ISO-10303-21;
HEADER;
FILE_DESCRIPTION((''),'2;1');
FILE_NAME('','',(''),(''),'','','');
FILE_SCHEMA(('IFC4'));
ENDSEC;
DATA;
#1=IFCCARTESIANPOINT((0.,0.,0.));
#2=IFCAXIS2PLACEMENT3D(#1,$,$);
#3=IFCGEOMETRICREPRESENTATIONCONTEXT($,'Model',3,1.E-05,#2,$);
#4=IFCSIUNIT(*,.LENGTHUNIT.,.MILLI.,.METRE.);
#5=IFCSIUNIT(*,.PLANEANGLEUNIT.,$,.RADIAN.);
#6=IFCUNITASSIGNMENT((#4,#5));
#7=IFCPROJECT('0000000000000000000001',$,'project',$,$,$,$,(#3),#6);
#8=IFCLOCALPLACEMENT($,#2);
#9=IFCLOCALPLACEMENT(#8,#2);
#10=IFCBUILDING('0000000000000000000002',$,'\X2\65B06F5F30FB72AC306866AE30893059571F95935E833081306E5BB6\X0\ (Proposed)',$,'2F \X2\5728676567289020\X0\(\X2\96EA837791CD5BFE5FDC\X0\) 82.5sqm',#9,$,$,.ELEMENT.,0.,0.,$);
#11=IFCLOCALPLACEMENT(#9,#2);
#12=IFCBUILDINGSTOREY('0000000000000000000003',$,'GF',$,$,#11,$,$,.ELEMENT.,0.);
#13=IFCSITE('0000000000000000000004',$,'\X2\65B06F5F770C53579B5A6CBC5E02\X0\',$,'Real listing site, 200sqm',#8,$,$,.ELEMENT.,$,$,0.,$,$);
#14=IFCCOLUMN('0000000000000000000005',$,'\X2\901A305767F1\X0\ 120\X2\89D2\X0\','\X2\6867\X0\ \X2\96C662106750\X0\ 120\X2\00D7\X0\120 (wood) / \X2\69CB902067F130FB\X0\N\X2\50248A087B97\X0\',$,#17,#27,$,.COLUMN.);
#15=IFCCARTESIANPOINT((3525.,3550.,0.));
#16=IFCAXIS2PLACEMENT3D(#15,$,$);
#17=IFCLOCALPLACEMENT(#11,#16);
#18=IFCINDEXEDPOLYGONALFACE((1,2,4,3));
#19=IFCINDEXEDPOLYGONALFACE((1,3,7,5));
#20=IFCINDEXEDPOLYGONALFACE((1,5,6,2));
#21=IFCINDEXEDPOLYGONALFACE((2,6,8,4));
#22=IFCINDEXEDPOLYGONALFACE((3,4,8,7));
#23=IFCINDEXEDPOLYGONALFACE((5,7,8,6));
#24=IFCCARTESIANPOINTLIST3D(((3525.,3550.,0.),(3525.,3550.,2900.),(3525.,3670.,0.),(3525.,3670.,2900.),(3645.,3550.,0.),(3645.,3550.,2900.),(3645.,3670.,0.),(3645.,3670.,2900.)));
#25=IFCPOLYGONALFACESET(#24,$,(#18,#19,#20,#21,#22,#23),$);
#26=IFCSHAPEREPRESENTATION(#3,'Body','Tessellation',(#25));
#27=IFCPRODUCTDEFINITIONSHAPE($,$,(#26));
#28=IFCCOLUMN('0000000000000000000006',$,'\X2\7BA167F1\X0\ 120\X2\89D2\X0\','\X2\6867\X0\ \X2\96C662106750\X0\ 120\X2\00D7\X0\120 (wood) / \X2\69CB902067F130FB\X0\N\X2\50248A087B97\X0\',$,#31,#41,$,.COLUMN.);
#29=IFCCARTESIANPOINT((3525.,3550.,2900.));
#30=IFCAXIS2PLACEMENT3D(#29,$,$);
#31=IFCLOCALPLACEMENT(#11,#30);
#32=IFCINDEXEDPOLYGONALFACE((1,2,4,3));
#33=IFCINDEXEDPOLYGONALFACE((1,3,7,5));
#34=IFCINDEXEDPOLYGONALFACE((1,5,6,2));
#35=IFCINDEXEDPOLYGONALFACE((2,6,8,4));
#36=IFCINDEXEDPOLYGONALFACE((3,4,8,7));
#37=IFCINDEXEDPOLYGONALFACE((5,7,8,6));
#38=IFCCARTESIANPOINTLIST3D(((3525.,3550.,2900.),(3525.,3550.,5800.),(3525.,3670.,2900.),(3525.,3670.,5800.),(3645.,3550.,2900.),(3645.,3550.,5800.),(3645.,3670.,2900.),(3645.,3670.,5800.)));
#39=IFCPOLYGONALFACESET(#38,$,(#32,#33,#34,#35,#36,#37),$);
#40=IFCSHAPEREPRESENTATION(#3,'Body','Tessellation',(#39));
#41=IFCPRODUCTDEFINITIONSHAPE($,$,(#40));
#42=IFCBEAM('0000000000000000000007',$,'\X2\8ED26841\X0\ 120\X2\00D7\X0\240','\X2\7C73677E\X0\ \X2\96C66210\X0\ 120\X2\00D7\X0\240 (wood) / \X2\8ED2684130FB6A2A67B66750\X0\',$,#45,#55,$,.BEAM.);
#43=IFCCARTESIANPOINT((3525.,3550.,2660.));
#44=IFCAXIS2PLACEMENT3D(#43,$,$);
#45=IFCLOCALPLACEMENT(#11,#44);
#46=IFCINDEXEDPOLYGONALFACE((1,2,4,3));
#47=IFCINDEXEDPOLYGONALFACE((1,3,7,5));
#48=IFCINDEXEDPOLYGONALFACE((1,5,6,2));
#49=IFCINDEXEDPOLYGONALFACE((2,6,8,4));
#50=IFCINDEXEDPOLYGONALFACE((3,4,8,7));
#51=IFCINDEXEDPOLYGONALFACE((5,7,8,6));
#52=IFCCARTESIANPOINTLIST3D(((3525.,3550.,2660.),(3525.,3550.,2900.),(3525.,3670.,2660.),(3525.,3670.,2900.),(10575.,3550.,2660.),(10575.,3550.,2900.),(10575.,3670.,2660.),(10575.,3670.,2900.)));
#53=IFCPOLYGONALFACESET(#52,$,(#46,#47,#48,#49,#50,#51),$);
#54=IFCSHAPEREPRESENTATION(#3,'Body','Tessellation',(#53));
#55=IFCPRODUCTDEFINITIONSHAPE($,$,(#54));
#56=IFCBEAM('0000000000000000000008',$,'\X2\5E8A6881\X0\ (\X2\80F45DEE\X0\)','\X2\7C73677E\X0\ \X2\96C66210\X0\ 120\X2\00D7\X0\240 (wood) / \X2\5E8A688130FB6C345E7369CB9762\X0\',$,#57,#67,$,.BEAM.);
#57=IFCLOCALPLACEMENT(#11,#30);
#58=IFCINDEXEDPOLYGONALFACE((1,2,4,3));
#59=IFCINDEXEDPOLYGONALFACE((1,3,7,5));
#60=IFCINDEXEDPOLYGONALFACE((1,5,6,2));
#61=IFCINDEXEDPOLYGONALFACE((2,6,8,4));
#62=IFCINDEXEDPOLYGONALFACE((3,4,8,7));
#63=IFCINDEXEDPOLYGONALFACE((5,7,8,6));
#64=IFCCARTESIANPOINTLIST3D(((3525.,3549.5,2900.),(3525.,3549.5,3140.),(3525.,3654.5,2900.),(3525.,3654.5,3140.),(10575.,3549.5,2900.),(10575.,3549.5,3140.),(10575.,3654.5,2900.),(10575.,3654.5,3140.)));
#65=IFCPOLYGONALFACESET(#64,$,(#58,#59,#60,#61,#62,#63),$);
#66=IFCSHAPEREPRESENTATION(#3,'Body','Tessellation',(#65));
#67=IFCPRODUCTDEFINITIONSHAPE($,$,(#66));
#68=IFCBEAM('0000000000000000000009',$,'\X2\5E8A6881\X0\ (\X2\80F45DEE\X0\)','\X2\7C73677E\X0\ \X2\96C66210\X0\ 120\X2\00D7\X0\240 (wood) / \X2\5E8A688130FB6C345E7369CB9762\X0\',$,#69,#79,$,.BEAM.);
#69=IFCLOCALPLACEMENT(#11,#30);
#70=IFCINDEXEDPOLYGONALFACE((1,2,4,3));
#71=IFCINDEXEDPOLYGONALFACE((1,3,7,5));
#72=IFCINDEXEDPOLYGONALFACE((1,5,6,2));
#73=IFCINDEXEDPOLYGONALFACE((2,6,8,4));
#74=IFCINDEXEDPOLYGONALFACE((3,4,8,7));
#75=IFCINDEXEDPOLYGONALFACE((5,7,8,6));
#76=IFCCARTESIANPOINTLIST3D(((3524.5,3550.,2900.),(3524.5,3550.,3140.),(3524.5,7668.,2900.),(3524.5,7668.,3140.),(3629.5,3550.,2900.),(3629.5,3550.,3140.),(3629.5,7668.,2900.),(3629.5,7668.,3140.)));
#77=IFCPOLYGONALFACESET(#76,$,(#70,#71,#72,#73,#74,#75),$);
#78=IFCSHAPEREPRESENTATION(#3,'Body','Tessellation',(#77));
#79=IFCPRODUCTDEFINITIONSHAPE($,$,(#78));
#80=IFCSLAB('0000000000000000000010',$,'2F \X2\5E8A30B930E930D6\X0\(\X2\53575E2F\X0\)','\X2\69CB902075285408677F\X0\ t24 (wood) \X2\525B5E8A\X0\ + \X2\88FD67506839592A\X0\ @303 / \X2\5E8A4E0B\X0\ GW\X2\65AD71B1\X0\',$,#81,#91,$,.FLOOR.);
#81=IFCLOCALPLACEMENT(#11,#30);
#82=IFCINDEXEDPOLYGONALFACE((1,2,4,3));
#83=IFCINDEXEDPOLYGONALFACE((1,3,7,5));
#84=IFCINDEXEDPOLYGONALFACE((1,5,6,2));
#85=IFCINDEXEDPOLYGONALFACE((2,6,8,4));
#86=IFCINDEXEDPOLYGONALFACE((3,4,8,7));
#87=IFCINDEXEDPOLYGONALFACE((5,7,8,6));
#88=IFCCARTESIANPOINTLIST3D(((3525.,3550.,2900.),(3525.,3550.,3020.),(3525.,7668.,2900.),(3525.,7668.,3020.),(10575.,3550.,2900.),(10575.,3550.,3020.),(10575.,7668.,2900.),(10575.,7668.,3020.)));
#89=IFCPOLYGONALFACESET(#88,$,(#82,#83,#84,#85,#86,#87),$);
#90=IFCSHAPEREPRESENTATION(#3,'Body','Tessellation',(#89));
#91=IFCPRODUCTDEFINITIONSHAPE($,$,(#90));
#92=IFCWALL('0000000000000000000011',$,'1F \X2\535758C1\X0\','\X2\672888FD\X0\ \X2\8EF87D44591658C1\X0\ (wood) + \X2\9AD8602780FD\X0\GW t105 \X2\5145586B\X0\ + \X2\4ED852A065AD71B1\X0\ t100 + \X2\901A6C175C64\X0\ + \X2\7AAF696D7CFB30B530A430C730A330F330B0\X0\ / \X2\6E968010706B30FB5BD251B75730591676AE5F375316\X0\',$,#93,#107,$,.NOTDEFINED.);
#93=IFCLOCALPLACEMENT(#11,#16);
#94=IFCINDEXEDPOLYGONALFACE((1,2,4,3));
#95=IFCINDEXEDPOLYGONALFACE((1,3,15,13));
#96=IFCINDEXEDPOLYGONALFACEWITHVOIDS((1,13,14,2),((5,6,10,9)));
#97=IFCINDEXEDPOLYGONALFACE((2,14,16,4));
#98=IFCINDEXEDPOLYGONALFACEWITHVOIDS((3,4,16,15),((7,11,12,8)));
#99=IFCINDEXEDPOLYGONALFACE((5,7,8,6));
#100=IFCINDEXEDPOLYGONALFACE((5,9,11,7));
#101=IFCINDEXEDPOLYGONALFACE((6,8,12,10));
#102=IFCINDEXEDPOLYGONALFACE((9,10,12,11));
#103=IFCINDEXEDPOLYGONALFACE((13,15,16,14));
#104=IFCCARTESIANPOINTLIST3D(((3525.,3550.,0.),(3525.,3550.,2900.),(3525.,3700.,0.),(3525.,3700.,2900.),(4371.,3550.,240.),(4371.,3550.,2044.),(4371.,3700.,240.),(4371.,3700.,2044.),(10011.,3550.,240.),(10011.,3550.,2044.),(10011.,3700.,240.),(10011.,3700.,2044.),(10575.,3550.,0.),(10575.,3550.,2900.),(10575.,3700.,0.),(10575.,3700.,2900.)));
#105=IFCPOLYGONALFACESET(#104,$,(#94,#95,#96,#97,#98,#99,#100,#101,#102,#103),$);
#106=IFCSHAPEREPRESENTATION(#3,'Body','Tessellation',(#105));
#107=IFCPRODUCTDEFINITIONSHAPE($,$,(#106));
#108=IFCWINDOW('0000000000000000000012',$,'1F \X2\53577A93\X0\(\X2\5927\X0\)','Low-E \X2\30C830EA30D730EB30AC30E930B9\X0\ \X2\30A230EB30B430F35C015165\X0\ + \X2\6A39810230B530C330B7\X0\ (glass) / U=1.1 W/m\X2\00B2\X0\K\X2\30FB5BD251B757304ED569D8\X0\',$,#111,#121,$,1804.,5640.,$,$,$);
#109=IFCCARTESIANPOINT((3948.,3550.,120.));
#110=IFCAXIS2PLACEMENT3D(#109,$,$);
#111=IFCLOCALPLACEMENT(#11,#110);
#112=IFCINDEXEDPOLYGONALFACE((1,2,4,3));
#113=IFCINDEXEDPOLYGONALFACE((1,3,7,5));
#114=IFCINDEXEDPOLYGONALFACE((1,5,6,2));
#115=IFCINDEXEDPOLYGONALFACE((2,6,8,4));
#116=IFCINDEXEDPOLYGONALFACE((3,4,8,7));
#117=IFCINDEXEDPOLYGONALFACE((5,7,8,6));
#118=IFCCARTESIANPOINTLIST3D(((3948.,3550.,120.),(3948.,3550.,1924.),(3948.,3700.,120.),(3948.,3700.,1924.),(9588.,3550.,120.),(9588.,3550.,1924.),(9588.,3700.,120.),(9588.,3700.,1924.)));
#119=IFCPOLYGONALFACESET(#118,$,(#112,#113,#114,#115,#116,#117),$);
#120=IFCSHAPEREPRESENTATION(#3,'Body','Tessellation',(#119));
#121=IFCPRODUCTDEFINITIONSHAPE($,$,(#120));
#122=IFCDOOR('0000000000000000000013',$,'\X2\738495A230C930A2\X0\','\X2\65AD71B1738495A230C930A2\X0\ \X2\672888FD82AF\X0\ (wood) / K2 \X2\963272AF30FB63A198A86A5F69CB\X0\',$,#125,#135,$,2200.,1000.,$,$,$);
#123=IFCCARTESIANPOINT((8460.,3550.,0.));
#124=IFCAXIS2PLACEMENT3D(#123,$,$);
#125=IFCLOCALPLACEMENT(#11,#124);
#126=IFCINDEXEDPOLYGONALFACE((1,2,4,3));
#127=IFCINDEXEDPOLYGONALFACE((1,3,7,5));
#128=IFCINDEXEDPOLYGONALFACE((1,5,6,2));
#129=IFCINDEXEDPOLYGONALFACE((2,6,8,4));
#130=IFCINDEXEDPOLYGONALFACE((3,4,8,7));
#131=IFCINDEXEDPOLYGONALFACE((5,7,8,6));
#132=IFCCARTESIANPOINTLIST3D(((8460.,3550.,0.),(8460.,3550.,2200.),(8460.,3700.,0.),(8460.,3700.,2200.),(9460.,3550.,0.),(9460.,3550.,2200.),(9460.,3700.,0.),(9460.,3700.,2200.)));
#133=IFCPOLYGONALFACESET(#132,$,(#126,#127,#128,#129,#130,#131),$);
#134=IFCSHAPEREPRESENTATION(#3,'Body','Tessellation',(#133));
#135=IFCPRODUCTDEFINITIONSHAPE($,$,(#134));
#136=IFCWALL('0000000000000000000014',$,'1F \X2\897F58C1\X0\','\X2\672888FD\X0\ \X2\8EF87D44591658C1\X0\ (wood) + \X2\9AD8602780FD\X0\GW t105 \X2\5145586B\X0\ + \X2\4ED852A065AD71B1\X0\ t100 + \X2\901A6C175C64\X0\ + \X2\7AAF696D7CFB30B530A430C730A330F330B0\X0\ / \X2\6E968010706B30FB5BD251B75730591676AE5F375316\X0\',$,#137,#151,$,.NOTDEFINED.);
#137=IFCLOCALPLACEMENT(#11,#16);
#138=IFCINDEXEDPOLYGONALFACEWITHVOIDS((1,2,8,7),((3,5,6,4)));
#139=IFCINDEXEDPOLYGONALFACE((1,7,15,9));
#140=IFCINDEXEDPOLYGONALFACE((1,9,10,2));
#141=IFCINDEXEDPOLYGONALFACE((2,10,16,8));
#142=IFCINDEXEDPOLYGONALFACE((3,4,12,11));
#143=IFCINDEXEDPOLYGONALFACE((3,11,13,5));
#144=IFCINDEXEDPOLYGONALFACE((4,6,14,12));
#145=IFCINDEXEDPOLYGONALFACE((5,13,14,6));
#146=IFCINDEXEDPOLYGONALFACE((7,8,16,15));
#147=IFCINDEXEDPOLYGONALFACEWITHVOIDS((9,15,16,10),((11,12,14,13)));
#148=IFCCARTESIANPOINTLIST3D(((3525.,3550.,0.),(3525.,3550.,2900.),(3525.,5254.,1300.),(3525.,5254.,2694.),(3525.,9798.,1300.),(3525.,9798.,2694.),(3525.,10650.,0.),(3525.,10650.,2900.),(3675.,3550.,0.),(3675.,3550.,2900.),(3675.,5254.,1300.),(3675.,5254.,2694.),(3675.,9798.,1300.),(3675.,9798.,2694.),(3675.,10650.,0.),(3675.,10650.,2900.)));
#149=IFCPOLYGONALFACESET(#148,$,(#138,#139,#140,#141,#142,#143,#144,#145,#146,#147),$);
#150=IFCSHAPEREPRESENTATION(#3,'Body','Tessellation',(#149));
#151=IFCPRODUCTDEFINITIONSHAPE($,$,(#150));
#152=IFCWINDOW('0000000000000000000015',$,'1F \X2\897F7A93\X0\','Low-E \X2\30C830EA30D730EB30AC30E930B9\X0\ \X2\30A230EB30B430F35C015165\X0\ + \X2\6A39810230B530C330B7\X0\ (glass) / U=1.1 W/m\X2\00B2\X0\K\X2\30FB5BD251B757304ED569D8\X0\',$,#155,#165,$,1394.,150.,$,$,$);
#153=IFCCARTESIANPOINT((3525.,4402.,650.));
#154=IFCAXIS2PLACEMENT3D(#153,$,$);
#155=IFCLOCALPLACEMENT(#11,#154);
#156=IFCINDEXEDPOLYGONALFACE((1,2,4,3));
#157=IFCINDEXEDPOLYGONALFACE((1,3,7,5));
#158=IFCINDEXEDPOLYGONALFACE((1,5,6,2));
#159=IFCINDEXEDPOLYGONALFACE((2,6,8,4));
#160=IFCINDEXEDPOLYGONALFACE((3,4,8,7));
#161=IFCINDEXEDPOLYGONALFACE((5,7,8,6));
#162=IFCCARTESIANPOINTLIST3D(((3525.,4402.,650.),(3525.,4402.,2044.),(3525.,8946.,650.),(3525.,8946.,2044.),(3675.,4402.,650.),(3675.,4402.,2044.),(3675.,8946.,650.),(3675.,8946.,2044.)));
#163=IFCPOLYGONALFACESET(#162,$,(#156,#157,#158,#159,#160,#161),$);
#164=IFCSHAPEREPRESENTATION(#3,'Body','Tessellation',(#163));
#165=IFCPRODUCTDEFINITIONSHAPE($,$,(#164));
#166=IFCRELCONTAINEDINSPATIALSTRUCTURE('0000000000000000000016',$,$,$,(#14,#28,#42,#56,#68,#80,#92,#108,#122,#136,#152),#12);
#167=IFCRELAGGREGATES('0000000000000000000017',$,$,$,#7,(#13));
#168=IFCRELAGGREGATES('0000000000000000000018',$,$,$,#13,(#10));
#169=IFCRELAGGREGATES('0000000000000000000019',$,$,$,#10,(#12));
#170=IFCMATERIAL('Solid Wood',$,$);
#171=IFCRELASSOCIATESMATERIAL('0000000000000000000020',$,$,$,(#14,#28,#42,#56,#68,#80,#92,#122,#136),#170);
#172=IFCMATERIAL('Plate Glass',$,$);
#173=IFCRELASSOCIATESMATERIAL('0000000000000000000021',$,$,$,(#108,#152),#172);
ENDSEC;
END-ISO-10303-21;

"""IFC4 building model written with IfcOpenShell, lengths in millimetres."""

from ifc_helpers import new_model, si_unit, frame, frame_2d, origin, place, context, project, spatial, rectangle, extrude, material, element, fill, save


model = new_model("IFC4")

# Units and contexts
model_context = context("Model", 3, precision=1e-05, world=origin())
ifc_project = project(units=[si_unit("LENGTHUNIT", "METRE", prefix="MILLI"), si_unit("PLANEANGLEUNIT", "RADIAN")], contexts=[model_context])

# Site, building, storey
site_placement = place(None, origin())
site = spatial("IfcSite", under=ifc_project, at=site_placement, Name="新潟県南魚沼市", ObjectType="Real listing site, 200sqm", CompositionType="ELEMENT", RefElevation=0.0)
building_placement = place(site_placement, origin())
building = spatial("IfcBuilding", under=site, at=building_placement, Name="新潟・犬と暮らす土間広めの家 (Proposed)", ObjectType="2F 在来木造(雪荷重対応) 82.5sqm", CompositionType="ELEMENT", ElevationOfRefHeight=0.0, ElevationOfTerrain=0.0)
storey_placement = place(building_placement, origin())
storey = spatial("IfcBuildingStorey", under=building, at=storey_placement, Name="GF", CompositionType="ELEMENT", Elevation=0.0)

# Columns
ifc_material_1 = material(Name="Solid Wood")
column_1_placement = place(storey_placement, frame((3525.0, 3550.0, 0.0)))
element("IfcColumn", 1, at=column_1_placement, inside=storey, material=ifc_material_1, Name="通し柱 120角", Description="桧 集成材 120×120 (wood) / 構造柱・N値計算", PredefinedType="COLUMN", context=model_context, shape_type="SweptSolid", body=[
    extrude(rectangle(XDim=120.0, YDim=120.0, at=frame_2d((60.0, 60.0))), frame((3525.0, 3550.0, 0.0)), (0.0, 0.0, 1.0), 2900.0),
])
column_2_placement = place(storey_placement, frame((3525.0, 3550.0, 2900.0)))
element("IfcColumn", 2, at=column_2_placement, inside=storey, material=ifc_material_1, Name="管柱 120角", Description="桧 集成材 120×120 (wood) / 構造柱・N値計算", PredefinedType="COLUMN", context=model_context, shape_type="SweptSolid", body=[
    extrude(rectangle(XDim=120.0, YDim=120.0, at=frame_2d((60.0, 60.0))), frame((3525.0, 3550.0, 2900.0)), (0.0, 0.0, 1.0), 2900.0),
])

# Beams
beam_1_placement = place(storey_placement, frame((3525.0, 3550.0, 2660.0)))
element("IfcBeam", 3, at=beam_1_placement, inside=storey, material=ifc_material_1, Name="軒桁 120×240", Description="米松 集成 120×240 (wood) / 軒桁・横架材", PredefinedType="BEAM", context=model_context, shape_type="SweptSolid", body=[
    extrude(rectangle(XDim=7050.0, YDim=120.0, at=frame_2d((3525.0, 60.0))), frame((3525.0, 3550.0, 2660.0)), (0.0, 0.0, 1.0), 240.0),
])
beam_2_placement = place(storey_placement, frame((3525.0, 3550.0, 2900.0)))
element("IfcBeam", 4, at=beam_2_placement, inside=storey, material=ifc_material_1, Name="床梁 (胴差)", Description="米松 集成 120×240 (wood) / 床梁・水平構面", PredefinedType="BEAM", context=model_context, shape_type="SweptSolid", body=[
    extrude(rectangle(XDim=7050.0, YDim=105.0, at=frame_2d((3525.0, 52.0))), frame((3525.0, 3550.0, 2900.0)), (0.0, 0.0, 1.0), 240.0),
])
beam_3_placement = place(storey_placement, frame((3525.0, 3550.0, 2900.0)))
element("IfcBeam", 5, at=beam_3_placement, inside=storey, material=ifc_material_1, Name="床梁 (胴差)", Description="米松 集成 120×240 (wood) / 床梁・水平構面", PredefinedType="BEAM", context=model_context, shape_type="SweptSolid", body=[
    extrude(rectangle(XDim=105.0, YDim=4118.0, at=frame_2d((52.0, 2059.0))), frame((3525.0, 3550.0, 2900.0)), (0.0, 0.0, 1.0), 240.0),
])

# Slab
slab_1_placement = place(storey_placement, frame((3525.0, 3550.0, 2900.0)))
element("IfcSlab", 6, at=slab_1_placement, inside=storey, material=ifc_material_1, Name="2F 床スラブ(南帯)", Description="構造用合板 t24 (wood) 剛床 + 製材根太 @303 / 床下 GW断熱", PredefinedType="FLOOR", context=model_context, shape_type="SweptSolid", body=[
    extrude(rectangle(XDim=7050.0, YDim=4118.0, at=frame_2d((3525.0, 2059.0))), frame((3525.0, 3550.0, 2900.0)), (0.0, 0.0, 1.0), 120.0),
])

# Wall, openings, window, door
wall_1_placement = place(storey_placement, frame((3525.0, 3550.0, 0.0)))
wall_1 = element("IfcWall", 7, at=wall_1_placement, inside=storey, material=ifc_material_1, Name="1F 南壁", Description="木製 軸組外壁 (wood) + 高性能GW t105 充填 + 付加断熱 t100 + 通気層 + 窯業系サイディング / 準耐火・寒冷地外皮強化", PredefinedType="NOTDEFINED", context=model_context, shape_type="SweptSolid", body=[
    extrude(rectangle(XDim=7050.0, YDim=150.0, at=frame_2d((3525.0, 75.0))), frame((3525.0, 3550.0, 0.0)), (0.0, 0.0, 1.0), 2900.0),
])
opening_1_placement = place(storey_placement, frame((3948.0, 3550.0, 120.0)))
opening_1 = element("IfcOpeningElement", 8, at=opening_1_placement, cuts=wall_1, PredefinedType="NOTDEFINED", context=model_context, shape_type="SweptSolid", body=[
    extrude(rectangle(XDim=5640.0, YDim=150.0, at=frame_2d((2820.0, 75.0))), frame((3948.0, 3550.0, 120.0)), (0.0, 0.0, 1.0), 1804.0),
])
opening_2_placement = place(storey_placement, frame((8460.0, 3550.0, 0.0)))
opening_2 = element("IfcOpeningElement", 9, at=opening_2_placement, cuts=wall_1, PredefinedType="NOTDEFINED", context=model_context, shape_type="SweptSolid", body=[
    extrude(rectangle(XDim=1000.0, YDim=150.0, at=frame_2d((500.0, 75.0))), frame((8460.0, 3550.0, 0.0)), (0.0, 0.0, 1.0), 2200.0),
])
ifc_material_2 = material(Name="Plate Glass")
window_1_placement = place(storey_placement, frame((3948.0, 3550.0, 120.0)))
window_1 = element("IfcWindow", 10, at=window_1_placement, inside=storey, material=ifc_material_2, Name="1F 南窓(大)", Description="Low-E トリプルガラス アルゴン封入 + 樹脂サッシ (glass) / U=1.1 W/m²K・寒冷地仕様", OverallHeight=1804.0, OverallWidth=5640.0, context=model_context, shape_type="SweptSolid", body=[
    extrude(rectangle(XDim=5640.0, YDim=150.0, at=frame_2d((2820.0, 75.0))), frame((3948.0, 3550.0, 120.0)), (0.0, 0.0, 1.0), 1804.0),
])
fill(opening_1, window_1)
door_placement = place(storey_placement, frame((8460.0, 3550.0, 0.0)))
door = element("IfcDoor", 11, at=door_placement, inside=storey, material=ifc_material_1, Name="玄関ドア", Description="断熱玄関ドア 木製芯 (wood) / K2 防犯・採風機構", OverallHeight=2200.0, OverallWidth=1000.0, context=model_context, shape_type="SweptSolid", body=[
    extrude(rectangle(XDim=1000.0, YDim=150.0, at=frame_2d((500.0, 75.0))), frame((8460.0, 3550.0, 0.0)), (0.0, 0.0, 1.0), 2200.0),
])
fill(opening_2, door)

# Wall, opening, window
wall_2_placement = place(storey_placement, frame((3525.0, 3550.0, 0.0)))
wall_2 = element("IfcWall", 12, at=wall_2_placement, inside=storey, material=ifc_material_1, Name="1F 西壁", Description="木製 軸組外壁 (wood) + 高性能GW t105 充填 + 付加断熱 t100 + 通気層 + 窯業系サイディング / 準耐火・寒冷地外皮強化", PredefinedType="NOTDEFINED", context=model_context, shape_type="SweptSolid", body=[
    extrude(rectangle(XDim=150.0, YDim=7100.0, at=frame_2d((75.0, 3550.0))), frame((3525.0, 3550.0, 0.0)), (0.0, 0.0, 1.0), 2900.0),
])
opening_3_placement = place(storey_placement, frame((3525.0, 4402.0, 650.0)))
opening_3 = element("IfcOpeningElement", 13, at=opening_3_placement, cuts=wall_2, PredefinedType="NOTDEFINED", context=model_context, shape_type="SweptSolid", body=[
    extrude(rectangle(XDim=150.0, YDim=4544.0, at=frame_2d((75.0, 2272.0))), frame((3525.0, 4402.0, 650.0)), (0.0, 0.0, 1.0), 1394.0),
])
window_2_placement = place(storey_placement, frame((3525.0, 4402.0, 650.0)))
window_2 = element("IfcWindow", 14, at=window_2_placement, inside=storey, material=ifc_material_2, Name="1F 西窓", Description="Low-E トリプルガラス アルゴン封入 + 樹脂サッシ (glass) / U=1.1 W/m²K・寒冷地仕様", OverallHeight=1394.0, OverallWidth=150.0, context=model_context, shape_type="SweptSolid", body=[
    extrude(rectangle(XDim=150.0, YDim=4544.0, at=frame_2d((75.0, 2272.0))), frame((3525.0, 4402.0, 650.0)), (0.0, 0.0, 1.0), 1394.0),
])
fill(opening_3, window_2)

save(model, "model.ifc")
